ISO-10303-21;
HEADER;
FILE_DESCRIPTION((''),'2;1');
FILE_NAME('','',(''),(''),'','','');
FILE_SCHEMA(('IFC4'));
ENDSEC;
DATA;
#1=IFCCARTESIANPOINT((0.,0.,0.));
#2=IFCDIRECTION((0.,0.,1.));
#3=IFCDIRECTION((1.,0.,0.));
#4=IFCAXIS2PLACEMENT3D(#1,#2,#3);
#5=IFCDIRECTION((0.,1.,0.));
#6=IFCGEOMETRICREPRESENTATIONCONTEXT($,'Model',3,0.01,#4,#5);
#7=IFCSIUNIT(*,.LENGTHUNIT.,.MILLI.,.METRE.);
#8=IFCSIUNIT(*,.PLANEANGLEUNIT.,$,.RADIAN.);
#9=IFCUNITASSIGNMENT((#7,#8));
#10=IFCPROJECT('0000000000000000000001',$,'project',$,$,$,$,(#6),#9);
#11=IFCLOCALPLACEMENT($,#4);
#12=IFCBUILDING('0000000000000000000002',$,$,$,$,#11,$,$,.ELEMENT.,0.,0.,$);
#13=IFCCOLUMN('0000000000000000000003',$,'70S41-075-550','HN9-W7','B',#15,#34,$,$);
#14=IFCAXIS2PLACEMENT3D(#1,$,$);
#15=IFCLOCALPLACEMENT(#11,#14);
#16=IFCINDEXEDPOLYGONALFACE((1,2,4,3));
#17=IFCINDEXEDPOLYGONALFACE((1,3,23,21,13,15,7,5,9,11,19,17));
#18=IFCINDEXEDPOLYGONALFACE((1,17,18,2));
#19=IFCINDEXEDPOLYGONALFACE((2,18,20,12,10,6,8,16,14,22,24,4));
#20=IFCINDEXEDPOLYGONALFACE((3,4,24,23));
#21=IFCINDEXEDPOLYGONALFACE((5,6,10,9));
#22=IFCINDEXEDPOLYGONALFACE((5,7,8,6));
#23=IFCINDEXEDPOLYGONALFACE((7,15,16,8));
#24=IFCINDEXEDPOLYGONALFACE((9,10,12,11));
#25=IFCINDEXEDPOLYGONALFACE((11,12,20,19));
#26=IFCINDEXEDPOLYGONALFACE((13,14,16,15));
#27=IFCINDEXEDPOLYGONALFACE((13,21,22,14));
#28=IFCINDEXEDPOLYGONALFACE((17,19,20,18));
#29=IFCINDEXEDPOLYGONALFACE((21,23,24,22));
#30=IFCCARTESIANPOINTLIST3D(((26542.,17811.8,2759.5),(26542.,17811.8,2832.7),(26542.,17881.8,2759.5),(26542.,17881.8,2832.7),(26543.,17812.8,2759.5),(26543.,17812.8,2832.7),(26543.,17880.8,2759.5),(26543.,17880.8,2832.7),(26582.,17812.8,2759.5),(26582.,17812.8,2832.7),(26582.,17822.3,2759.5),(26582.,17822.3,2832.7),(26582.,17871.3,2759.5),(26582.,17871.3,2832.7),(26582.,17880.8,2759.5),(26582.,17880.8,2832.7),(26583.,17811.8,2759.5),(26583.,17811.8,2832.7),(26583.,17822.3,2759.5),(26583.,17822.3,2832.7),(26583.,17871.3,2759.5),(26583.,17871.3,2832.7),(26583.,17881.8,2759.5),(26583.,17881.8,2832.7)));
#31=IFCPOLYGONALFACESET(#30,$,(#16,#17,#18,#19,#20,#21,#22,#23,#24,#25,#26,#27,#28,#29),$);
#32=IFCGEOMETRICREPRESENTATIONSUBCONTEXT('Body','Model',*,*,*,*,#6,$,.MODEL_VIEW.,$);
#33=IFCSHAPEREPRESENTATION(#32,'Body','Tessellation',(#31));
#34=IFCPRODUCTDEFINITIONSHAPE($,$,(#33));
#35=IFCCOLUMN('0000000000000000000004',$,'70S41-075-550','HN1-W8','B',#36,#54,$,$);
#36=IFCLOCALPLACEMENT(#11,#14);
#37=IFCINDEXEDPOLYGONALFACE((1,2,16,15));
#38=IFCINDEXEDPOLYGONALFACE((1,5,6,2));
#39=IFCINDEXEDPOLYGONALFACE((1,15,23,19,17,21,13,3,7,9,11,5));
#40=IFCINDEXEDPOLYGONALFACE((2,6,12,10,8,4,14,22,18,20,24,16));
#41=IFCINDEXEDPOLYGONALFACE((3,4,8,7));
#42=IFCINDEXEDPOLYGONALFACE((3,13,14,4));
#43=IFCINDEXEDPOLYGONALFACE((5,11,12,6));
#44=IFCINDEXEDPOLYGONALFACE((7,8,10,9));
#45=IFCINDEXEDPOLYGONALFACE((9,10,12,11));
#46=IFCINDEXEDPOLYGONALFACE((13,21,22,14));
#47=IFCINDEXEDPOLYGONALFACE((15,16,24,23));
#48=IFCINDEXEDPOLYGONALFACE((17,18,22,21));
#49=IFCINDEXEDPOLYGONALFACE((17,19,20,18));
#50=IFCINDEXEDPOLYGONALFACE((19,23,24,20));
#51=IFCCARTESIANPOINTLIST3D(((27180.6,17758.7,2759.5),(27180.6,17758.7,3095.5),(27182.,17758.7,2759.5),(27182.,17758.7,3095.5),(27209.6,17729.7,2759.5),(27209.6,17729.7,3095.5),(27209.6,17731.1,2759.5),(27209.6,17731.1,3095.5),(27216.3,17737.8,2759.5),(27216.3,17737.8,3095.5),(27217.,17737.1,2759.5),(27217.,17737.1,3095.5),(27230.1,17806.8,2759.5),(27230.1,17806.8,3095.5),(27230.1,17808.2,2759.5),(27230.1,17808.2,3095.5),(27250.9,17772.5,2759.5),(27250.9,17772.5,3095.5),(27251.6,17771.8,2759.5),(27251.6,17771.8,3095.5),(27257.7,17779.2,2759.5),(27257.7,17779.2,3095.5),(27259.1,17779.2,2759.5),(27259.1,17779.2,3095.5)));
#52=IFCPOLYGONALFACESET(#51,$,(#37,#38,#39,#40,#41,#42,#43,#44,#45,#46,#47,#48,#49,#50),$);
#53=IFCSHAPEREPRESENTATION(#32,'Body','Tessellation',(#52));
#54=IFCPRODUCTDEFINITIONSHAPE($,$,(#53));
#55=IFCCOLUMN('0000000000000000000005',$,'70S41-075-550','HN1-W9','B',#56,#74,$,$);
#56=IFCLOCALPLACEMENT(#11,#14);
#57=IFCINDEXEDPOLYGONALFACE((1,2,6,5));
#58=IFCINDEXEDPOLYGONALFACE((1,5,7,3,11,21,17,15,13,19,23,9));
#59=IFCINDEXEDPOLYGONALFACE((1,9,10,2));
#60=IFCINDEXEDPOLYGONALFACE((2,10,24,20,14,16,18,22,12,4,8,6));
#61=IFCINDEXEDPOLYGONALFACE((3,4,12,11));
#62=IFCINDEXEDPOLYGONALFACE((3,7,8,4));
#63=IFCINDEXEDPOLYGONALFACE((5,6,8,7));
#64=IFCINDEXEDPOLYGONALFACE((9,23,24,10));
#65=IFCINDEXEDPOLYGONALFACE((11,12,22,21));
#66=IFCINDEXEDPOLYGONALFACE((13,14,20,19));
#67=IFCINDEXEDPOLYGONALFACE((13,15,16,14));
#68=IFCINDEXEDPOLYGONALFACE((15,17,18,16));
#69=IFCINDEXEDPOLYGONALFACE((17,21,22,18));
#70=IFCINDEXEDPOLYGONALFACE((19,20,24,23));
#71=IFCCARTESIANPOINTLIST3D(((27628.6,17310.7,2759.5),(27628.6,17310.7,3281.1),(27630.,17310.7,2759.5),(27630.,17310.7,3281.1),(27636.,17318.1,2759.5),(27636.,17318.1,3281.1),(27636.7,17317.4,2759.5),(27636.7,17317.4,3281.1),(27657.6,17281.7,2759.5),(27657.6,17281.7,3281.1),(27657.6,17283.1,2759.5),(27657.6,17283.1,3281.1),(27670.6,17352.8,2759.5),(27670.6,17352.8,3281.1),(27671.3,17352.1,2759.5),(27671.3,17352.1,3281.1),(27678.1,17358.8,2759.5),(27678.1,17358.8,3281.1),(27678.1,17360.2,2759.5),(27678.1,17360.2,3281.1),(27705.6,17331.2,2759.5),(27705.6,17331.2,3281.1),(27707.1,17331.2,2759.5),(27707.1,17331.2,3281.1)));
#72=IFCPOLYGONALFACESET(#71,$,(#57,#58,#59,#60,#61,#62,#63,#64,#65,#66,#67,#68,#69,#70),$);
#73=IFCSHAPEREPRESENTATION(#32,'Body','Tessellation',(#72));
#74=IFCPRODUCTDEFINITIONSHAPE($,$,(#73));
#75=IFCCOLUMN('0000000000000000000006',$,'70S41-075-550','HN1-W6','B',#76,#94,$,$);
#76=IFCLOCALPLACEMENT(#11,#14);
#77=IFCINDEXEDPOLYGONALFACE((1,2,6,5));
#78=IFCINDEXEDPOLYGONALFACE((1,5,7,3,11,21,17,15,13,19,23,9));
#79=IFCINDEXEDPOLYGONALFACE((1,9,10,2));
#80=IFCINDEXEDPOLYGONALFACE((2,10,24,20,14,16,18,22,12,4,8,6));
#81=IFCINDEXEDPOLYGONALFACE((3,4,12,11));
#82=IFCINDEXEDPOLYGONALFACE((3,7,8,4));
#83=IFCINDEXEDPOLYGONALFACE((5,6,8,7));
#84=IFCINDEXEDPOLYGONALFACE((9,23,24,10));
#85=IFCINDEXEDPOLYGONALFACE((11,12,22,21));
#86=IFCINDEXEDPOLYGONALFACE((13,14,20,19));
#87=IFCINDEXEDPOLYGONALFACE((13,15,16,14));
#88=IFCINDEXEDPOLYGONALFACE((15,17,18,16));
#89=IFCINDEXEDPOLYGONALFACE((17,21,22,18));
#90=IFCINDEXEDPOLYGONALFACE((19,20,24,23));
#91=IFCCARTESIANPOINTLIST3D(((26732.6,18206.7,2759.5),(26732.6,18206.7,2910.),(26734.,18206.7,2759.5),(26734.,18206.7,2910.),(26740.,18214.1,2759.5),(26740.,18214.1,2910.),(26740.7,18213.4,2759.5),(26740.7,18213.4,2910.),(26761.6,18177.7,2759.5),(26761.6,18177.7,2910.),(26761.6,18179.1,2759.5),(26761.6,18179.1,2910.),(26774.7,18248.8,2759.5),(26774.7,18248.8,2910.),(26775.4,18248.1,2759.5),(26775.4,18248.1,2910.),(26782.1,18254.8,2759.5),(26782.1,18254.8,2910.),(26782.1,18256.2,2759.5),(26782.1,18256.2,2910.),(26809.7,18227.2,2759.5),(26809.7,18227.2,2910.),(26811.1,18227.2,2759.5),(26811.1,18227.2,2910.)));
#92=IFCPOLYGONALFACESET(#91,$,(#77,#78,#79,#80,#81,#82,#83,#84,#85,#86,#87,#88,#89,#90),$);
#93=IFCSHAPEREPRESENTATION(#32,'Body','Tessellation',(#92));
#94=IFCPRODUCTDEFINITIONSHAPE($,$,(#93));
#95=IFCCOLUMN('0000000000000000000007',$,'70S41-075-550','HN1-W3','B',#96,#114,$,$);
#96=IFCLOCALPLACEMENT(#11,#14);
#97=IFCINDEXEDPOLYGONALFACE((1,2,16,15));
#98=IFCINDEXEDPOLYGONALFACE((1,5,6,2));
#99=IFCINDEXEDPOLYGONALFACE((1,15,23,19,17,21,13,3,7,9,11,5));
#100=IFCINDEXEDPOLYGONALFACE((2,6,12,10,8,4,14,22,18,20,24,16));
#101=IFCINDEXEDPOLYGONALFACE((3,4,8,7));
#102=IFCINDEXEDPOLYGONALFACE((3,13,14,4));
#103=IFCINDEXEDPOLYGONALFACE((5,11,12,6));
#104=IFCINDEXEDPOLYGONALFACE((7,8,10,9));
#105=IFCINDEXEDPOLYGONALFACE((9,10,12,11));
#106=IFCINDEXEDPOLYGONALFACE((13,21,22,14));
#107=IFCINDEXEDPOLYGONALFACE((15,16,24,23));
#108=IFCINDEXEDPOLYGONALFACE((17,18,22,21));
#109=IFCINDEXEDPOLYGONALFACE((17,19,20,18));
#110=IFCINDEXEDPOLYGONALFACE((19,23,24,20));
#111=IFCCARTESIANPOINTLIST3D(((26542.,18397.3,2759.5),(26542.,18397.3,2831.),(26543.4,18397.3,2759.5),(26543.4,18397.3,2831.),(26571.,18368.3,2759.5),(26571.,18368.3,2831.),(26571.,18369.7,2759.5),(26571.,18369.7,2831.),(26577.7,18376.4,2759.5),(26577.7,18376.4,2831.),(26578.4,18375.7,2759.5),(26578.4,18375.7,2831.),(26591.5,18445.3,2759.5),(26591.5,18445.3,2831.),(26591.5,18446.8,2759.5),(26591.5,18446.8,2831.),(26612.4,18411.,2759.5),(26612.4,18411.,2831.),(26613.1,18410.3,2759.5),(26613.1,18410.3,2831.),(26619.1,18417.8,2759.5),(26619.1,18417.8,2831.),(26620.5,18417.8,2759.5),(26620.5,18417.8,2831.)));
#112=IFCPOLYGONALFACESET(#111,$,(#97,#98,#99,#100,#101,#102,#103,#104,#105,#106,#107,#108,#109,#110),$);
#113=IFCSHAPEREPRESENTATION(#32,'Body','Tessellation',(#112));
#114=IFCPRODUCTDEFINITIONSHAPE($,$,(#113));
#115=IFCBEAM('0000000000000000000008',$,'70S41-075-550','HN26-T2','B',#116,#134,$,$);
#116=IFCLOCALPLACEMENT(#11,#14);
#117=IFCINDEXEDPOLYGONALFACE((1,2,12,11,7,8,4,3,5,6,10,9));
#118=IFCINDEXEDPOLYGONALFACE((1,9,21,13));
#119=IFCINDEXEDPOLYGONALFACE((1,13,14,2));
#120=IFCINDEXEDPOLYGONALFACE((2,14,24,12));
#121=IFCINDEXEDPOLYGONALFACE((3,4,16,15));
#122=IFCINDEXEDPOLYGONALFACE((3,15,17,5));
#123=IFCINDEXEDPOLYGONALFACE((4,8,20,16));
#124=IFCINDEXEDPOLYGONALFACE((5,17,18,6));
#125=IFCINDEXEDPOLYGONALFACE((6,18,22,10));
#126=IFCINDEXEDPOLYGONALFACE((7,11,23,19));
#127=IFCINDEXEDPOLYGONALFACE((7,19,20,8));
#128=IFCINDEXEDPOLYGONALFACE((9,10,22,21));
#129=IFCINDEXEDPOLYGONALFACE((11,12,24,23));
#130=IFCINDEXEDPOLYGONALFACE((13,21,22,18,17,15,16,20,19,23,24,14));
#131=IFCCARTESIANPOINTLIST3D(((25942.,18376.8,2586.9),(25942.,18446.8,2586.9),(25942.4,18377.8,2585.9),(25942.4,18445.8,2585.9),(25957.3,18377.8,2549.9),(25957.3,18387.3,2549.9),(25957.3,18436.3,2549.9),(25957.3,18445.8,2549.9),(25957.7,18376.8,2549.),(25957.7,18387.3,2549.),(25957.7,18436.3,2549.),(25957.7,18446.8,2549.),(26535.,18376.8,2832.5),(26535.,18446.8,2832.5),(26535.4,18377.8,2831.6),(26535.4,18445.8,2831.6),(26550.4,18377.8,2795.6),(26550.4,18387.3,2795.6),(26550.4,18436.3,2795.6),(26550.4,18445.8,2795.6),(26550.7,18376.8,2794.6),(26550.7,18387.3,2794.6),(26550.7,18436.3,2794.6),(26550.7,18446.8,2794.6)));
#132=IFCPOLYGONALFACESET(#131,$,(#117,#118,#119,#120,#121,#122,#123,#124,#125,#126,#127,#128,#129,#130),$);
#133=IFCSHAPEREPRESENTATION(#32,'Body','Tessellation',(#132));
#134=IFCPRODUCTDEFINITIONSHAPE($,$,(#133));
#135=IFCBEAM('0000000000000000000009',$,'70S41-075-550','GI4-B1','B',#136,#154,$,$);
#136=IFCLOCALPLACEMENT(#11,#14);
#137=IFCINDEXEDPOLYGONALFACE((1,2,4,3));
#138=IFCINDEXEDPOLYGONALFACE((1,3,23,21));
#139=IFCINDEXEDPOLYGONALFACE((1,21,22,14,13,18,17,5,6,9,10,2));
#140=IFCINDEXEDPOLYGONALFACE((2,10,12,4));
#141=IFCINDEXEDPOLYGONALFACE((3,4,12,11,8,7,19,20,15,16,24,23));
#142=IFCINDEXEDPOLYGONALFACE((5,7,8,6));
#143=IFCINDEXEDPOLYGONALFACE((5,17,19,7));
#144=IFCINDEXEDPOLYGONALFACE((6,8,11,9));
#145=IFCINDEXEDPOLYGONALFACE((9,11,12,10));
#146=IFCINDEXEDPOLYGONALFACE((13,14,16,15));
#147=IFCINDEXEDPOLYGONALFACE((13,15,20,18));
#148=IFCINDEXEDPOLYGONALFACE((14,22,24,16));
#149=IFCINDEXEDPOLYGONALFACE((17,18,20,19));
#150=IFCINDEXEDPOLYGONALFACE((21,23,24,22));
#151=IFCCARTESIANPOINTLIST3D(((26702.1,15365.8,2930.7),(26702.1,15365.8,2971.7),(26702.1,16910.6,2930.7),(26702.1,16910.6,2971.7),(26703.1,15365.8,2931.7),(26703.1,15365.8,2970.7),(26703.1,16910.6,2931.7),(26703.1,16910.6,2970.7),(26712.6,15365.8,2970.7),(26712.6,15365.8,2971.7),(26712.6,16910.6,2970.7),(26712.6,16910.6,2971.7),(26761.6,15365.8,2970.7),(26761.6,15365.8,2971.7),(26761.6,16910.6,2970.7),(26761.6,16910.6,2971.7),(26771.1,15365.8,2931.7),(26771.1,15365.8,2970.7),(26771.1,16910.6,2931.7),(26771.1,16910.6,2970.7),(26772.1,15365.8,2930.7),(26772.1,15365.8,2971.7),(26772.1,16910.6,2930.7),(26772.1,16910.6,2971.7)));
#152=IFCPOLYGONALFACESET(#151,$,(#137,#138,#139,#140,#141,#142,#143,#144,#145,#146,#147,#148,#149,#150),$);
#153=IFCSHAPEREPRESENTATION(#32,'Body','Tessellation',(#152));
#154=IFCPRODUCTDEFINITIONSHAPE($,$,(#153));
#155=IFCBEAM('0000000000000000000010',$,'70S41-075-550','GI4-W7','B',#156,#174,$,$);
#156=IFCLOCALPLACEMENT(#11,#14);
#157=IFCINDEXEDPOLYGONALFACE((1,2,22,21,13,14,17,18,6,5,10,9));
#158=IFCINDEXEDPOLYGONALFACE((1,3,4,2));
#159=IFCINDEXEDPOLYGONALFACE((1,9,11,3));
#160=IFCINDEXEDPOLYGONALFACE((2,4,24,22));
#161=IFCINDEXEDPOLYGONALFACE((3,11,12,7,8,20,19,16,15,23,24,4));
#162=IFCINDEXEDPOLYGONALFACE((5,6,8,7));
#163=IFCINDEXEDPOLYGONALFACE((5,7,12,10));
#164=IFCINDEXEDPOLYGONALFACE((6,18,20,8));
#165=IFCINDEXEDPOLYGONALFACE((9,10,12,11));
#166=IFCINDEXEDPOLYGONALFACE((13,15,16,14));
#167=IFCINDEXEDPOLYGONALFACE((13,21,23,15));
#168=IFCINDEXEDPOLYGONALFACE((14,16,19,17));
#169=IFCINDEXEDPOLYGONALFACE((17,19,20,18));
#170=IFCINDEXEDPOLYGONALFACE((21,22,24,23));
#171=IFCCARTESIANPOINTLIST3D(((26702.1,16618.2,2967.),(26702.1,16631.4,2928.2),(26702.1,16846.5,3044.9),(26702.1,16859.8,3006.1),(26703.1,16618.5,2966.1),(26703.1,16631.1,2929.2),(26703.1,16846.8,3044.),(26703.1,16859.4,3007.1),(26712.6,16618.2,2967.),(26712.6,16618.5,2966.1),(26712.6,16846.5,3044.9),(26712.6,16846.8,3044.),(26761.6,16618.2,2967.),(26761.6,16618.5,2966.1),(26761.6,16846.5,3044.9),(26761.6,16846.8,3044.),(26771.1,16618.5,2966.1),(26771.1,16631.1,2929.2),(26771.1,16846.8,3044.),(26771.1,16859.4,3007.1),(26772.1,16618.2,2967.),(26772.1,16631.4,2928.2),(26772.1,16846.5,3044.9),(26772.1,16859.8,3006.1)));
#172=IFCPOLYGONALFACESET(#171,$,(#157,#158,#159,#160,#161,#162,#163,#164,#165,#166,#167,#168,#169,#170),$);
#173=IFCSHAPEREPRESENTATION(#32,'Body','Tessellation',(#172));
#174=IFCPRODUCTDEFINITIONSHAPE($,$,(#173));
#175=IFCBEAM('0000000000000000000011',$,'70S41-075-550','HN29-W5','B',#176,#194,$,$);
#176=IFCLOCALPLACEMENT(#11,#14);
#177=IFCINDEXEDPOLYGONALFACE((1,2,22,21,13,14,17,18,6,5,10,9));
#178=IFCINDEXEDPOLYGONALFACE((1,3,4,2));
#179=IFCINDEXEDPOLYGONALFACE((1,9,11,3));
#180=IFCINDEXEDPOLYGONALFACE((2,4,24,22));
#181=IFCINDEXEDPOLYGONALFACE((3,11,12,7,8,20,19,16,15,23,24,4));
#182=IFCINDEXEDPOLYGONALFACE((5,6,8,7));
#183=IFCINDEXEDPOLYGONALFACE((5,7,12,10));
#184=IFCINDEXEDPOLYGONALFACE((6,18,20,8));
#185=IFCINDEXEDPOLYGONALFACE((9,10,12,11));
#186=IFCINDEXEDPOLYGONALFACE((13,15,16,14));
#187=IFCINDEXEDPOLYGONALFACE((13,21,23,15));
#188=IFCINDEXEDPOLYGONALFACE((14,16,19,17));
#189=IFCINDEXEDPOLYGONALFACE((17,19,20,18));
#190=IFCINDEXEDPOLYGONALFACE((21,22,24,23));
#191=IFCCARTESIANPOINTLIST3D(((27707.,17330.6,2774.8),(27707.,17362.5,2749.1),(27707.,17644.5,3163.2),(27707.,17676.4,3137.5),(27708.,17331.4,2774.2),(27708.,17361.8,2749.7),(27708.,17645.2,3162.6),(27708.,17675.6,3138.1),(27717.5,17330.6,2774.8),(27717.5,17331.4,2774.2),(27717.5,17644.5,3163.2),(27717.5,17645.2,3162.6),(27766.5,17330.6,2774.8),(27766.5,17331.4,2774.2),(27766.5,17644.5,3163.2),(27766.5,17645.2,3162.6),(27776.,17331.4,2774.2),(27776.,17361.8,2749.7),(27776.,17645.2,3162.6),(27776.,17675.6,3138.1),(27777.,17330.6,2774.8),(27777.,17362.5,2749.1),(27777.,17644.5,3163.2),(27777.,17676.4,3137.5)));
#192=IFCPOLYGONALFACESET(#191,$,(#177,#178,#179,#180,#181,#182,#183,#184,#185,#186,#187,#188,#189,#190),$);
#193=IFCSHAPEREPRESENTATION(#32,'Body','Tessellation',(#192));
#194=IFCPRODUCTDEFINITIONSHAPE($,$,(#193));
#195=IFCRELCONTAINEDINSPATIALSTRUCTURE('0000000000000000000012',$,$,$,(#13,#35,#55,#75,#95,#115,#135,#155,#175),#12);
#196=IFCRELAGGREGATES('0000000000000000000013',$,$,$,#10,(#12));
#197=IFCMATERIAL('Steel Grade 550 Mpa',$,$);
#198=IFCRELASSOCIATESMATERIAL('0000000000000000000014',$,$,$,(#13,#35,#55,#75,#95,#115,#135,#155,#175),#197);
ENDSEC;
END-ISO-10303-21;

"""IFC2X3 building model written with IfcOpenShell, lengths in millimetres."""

from ifc_helpers import new_model, si_unit, direction, frame, origin, origin_with_axes, origin_2d_with_axis, place, context, subcontext, project, spatial, c_section, extrude, source, transform, mapped, material, element, save


model = new_model("IFC2X3")

# Units and contexts
model_context = context("Model", 3, precision=0.01, world=origin_with_axes(), true_north=direction((0.0, 1.0, 0.0)))
body_context = subcontext(model_context, "Body", "Model", "MODEL_VIEW")
ifc_project = project(units=[si_unit("LENGTHUNIT", "METRE", prefix="MILLI"), si_unit("PLANEANGLEUNIT", "RADIAN")], contexts=[model_context])

# Building
building_placement = place(None, origin_with_axes())
building = spatial("IfcBuilding", under=ifc_project, at=building_placement, CompositionType="ELEMENT", ElevationOfRefHeight=0.0, ElevationOfTerrain=0.0)

# Columns
ifc_material = material(Name="Steel Grade 550 Mpa")
shared_shape_1 = source(origin(), body_context, "Body", "SweptSolid", [
    extrude(c_section(Depth=70.0, Width=41.0, WallThickness=1.0, Girth=10.5, at=origin_2d_with_axis()), origin_with_axes(), (0.0, 0.0, 1.0), 73.2),
])
column_1_placement = place(None, frame((26562.5, 17846.8, 2832.7), z_axis=(0.0, 0.0, -1.0), x_axis=(1.0, 0.0, 0.0)))
element("IfcColumn", 1, at=column_1_placement, inside=building, material=ifc_material, Name="70S41-075-550", Description="HN9-W7", ObjectType="B", context=body_context, shape_type="MappedRepresentation", body=[
    mapped(shared_shape_1, transform((0.0, 0.0, 0.0), scale=1.0)),
])
shared_shape_2 = source(origin(), body_context, "Body", "SweptSolid", [
    extrude(c_section(Depth=70.0, Width=41.0, WallThickness=1.0, Girth=10.5, at=origin_2d_with_axis()), origin_with_axes(), (0.0, 0.0, 1.0), 336.0),
])
column_2_placement = place(None, frame((27219.8, 17769.0, 3095.5), z_axis=(0.0, 0.0, -1.0), x_axis=(0.707107, -0.707107, 0.0)))
element("IfcColumn", 2, at=column_2_placement, inside=building, material=ifc_material, Name="70S41-075-550", Description="HN1-W8", ObjectType="B", context=body_context, shape_type="MappedRepresentation", body=[
    mapped(shared_shape_2, transform((0.0, 0.0, 0.0), scale=1.0)),
])
shared_shape_3 = source(origin(), body_context, "Body", "SweptSolid", [
    extrude(c_section(Depth=70.0, Width=41.0, WallThickness=1.0, Girth=10.5, at=origin_2d_with_axis()), origin_with_axes(), (0.0, 0.0, 1.0), 521.6),
])
column_3_placement = place(None, frame((27667.8, 17321.0, 2759.5), z_axis=(0.0, 0.0, 1.0), x_axis=(-0.707107, 0.707107, 0.0)))
element("IfcColumn", 3, at=column_3_placement, inside=building, material=ifc_material, Name="70S41-075-550", Description="HN1-W9", ObjectType="B", context=body_context, shape_type="MappedRepresentation", body=[
    mapped(shared_shape_3, transform((0.0, 0.0, 0.0), scale=1.0)),
])
shared_shape_4 = source(origin(), body_context, "Body", "SweptSolid", [
    extrude(c_section(Depth=70.0, Width=41.0, WallThickness=1.0, Girth=10.5, at=origin_2d_with_axis()), origin_with_axes(), (0.0, 0.0, 1.0), 150.5),
])
column_4_placement = place(None, frame((26771.8, 18216.9, 2759.5), z_axis=(0.0, 0.0, 1.0), x_axis=(-0.707107, 0.707107, 0.0)))
element("IfcColumn", 4, at=column_4_placement, inside=building, material=ifc_material, Name="70S41-075-550", Description="HN1-W6", ObjectType="B", context=body_context, shape_type="MappedRepresentation", body=[
    mapped(shared_shape_4, transform((0.0, 0.0, 0.0), scale=1.0)),
])
shared_shape_5 = source(origin(), body_context, "Body", "SweptSolid", [
    extrude(c_section(Depth=70.0, Width=41.0, WallThickness=1.0, Girth=10.5, at=origin_2d_with_axis()), origin_with_axes(), (0.0, 0.0, 1.0), 71.5),
])
column_5_placement = place(None, frame((26581.3, 18407.5, 2831.0), z_axis=(0.0, 0.0, -1.0), x_axis=(0.707107, -0.707107, 0.0)))
element("IfcColumn", 5, at=column_5_placement, inside=building, material=ifc_material, Name="70S41-075-550", Description="HN1-W3", ObjectType="B", context=body_context, shape_type="MappedRepresentation", body=[
    mapped(shared_shape_5, transform((0.0, 0.0, 0.0), scale=1.0)),
])

# Beams
shared_shape_6 = source(origin(), body_context, "Body", "SweptSolid", [
    extrude(c_section(Depth=70.0, Width=41.0, WallThickness=1.0, Girth=10.5, at=origin_2d_with_axis()), origin_with_axes(), (0.0, 0.0, 1.0), 641.9),
])
beam_1_placement = place(None, frame((26542.9, 18411.8, 2813.6), z_axis=(-0.92388, 0.0, -0.382683), x_axis=(0.382683, 0.0, -0.92388)))
element("IfcBeam", 6, at=beam_1_placement, inside=building, material=ifc_material, Name="70S41-075-550", Description="HN26-T2", ObjectType="B", context=body_context, shape_type="MappedRepresentation", body=[
    mapped(shared_shape_6, transform((0.0, 0.0, 0.0), scale=1.0)),
])
shared_shape_7 = source(origin(), body_context, "Body", "SweptSolid", [
    extrude(c_section(Depth=70.0, Width=41.0, WallThickness=1.0, Girth=10.5, at=origin_2d_with_axis()), origin_with_axes(), (0.0, 0.0, 1.0), 1544.8),
])
beam_2_placement = place(None, frame((26737.1, 16910.6, 2951.2), z_axis=(0.0, -1.0, 0.0), x_axis=(0.0, 0.0, 1.0)))
element("IfcBeam", 7, at=beam_2_placement, inside=building, material=ifc_material, Name="70S41-075-550", Description="GI4-B1", ObjectType="B", context=body_context, shape_type="MappedRepresentation", body=[
    mapped(shared_shape_7, transform((0.0, 0.0, 0.0), scale=1.0)),
])
shared_shape_8 = source(origin(), body_context, "Body", "SweptSolid", [
    extrude(c_section(Depth=70.0, Width=41.0, WallThickness=1.0, Girth=10.5, at=origin_2d_with_axis()), origin_with_axes(), (0.0, 0.0, 1.0), 241.3),
])
beam_3_placement = place(None, frame((26737.1, 16853.1, 3025.5), z_axis=(0.0, -0.946412, -0.322961), x_axis=(0.0, -0.322961, 0.946412)))
element("IfcBeam", 8, at=beam_3_placement, inside=building, material=ifc_material, Name="70S41-075-550", Description="GI4-W7", ObjectType="B", context=body_context, shape_type="MappedRepresentation", body=[
    mapped(shared_shape_8, transform((0.0, 0.0, 0.0), scale=1.0)),
])
shared_shape_9 = source(origin(), body_context, "Body", "SweptSolid", [
    extrude(c_section(Depth=70.0, Width=41.0, WallThickness=1.0, Girth=10.5, at=origin_2d_with_axis()), origin_with_axes(), (0.0, 0.0, 1.0), 499.3),
])
beam_4_placement = place(None, frame((27742.0, 17660.4, 3150.3), z_axis=(0.0, -0.628483, -0.777823), x_axis=(0.0, -0.777823, 0.628483)))
element("IfcBeam", 9, at=beam_4_placement, inside=building, material=ifc_material, Name="70S41-075-550", Description="HN29-W5", ObjectType="B", context=body_context, shape_type="MappedRepresentation", body=[
    mapped(shared_shape_9, transform((0.0, 0.0, 0.0), scale=1.0)),
])

save(model, "model.ifc")
